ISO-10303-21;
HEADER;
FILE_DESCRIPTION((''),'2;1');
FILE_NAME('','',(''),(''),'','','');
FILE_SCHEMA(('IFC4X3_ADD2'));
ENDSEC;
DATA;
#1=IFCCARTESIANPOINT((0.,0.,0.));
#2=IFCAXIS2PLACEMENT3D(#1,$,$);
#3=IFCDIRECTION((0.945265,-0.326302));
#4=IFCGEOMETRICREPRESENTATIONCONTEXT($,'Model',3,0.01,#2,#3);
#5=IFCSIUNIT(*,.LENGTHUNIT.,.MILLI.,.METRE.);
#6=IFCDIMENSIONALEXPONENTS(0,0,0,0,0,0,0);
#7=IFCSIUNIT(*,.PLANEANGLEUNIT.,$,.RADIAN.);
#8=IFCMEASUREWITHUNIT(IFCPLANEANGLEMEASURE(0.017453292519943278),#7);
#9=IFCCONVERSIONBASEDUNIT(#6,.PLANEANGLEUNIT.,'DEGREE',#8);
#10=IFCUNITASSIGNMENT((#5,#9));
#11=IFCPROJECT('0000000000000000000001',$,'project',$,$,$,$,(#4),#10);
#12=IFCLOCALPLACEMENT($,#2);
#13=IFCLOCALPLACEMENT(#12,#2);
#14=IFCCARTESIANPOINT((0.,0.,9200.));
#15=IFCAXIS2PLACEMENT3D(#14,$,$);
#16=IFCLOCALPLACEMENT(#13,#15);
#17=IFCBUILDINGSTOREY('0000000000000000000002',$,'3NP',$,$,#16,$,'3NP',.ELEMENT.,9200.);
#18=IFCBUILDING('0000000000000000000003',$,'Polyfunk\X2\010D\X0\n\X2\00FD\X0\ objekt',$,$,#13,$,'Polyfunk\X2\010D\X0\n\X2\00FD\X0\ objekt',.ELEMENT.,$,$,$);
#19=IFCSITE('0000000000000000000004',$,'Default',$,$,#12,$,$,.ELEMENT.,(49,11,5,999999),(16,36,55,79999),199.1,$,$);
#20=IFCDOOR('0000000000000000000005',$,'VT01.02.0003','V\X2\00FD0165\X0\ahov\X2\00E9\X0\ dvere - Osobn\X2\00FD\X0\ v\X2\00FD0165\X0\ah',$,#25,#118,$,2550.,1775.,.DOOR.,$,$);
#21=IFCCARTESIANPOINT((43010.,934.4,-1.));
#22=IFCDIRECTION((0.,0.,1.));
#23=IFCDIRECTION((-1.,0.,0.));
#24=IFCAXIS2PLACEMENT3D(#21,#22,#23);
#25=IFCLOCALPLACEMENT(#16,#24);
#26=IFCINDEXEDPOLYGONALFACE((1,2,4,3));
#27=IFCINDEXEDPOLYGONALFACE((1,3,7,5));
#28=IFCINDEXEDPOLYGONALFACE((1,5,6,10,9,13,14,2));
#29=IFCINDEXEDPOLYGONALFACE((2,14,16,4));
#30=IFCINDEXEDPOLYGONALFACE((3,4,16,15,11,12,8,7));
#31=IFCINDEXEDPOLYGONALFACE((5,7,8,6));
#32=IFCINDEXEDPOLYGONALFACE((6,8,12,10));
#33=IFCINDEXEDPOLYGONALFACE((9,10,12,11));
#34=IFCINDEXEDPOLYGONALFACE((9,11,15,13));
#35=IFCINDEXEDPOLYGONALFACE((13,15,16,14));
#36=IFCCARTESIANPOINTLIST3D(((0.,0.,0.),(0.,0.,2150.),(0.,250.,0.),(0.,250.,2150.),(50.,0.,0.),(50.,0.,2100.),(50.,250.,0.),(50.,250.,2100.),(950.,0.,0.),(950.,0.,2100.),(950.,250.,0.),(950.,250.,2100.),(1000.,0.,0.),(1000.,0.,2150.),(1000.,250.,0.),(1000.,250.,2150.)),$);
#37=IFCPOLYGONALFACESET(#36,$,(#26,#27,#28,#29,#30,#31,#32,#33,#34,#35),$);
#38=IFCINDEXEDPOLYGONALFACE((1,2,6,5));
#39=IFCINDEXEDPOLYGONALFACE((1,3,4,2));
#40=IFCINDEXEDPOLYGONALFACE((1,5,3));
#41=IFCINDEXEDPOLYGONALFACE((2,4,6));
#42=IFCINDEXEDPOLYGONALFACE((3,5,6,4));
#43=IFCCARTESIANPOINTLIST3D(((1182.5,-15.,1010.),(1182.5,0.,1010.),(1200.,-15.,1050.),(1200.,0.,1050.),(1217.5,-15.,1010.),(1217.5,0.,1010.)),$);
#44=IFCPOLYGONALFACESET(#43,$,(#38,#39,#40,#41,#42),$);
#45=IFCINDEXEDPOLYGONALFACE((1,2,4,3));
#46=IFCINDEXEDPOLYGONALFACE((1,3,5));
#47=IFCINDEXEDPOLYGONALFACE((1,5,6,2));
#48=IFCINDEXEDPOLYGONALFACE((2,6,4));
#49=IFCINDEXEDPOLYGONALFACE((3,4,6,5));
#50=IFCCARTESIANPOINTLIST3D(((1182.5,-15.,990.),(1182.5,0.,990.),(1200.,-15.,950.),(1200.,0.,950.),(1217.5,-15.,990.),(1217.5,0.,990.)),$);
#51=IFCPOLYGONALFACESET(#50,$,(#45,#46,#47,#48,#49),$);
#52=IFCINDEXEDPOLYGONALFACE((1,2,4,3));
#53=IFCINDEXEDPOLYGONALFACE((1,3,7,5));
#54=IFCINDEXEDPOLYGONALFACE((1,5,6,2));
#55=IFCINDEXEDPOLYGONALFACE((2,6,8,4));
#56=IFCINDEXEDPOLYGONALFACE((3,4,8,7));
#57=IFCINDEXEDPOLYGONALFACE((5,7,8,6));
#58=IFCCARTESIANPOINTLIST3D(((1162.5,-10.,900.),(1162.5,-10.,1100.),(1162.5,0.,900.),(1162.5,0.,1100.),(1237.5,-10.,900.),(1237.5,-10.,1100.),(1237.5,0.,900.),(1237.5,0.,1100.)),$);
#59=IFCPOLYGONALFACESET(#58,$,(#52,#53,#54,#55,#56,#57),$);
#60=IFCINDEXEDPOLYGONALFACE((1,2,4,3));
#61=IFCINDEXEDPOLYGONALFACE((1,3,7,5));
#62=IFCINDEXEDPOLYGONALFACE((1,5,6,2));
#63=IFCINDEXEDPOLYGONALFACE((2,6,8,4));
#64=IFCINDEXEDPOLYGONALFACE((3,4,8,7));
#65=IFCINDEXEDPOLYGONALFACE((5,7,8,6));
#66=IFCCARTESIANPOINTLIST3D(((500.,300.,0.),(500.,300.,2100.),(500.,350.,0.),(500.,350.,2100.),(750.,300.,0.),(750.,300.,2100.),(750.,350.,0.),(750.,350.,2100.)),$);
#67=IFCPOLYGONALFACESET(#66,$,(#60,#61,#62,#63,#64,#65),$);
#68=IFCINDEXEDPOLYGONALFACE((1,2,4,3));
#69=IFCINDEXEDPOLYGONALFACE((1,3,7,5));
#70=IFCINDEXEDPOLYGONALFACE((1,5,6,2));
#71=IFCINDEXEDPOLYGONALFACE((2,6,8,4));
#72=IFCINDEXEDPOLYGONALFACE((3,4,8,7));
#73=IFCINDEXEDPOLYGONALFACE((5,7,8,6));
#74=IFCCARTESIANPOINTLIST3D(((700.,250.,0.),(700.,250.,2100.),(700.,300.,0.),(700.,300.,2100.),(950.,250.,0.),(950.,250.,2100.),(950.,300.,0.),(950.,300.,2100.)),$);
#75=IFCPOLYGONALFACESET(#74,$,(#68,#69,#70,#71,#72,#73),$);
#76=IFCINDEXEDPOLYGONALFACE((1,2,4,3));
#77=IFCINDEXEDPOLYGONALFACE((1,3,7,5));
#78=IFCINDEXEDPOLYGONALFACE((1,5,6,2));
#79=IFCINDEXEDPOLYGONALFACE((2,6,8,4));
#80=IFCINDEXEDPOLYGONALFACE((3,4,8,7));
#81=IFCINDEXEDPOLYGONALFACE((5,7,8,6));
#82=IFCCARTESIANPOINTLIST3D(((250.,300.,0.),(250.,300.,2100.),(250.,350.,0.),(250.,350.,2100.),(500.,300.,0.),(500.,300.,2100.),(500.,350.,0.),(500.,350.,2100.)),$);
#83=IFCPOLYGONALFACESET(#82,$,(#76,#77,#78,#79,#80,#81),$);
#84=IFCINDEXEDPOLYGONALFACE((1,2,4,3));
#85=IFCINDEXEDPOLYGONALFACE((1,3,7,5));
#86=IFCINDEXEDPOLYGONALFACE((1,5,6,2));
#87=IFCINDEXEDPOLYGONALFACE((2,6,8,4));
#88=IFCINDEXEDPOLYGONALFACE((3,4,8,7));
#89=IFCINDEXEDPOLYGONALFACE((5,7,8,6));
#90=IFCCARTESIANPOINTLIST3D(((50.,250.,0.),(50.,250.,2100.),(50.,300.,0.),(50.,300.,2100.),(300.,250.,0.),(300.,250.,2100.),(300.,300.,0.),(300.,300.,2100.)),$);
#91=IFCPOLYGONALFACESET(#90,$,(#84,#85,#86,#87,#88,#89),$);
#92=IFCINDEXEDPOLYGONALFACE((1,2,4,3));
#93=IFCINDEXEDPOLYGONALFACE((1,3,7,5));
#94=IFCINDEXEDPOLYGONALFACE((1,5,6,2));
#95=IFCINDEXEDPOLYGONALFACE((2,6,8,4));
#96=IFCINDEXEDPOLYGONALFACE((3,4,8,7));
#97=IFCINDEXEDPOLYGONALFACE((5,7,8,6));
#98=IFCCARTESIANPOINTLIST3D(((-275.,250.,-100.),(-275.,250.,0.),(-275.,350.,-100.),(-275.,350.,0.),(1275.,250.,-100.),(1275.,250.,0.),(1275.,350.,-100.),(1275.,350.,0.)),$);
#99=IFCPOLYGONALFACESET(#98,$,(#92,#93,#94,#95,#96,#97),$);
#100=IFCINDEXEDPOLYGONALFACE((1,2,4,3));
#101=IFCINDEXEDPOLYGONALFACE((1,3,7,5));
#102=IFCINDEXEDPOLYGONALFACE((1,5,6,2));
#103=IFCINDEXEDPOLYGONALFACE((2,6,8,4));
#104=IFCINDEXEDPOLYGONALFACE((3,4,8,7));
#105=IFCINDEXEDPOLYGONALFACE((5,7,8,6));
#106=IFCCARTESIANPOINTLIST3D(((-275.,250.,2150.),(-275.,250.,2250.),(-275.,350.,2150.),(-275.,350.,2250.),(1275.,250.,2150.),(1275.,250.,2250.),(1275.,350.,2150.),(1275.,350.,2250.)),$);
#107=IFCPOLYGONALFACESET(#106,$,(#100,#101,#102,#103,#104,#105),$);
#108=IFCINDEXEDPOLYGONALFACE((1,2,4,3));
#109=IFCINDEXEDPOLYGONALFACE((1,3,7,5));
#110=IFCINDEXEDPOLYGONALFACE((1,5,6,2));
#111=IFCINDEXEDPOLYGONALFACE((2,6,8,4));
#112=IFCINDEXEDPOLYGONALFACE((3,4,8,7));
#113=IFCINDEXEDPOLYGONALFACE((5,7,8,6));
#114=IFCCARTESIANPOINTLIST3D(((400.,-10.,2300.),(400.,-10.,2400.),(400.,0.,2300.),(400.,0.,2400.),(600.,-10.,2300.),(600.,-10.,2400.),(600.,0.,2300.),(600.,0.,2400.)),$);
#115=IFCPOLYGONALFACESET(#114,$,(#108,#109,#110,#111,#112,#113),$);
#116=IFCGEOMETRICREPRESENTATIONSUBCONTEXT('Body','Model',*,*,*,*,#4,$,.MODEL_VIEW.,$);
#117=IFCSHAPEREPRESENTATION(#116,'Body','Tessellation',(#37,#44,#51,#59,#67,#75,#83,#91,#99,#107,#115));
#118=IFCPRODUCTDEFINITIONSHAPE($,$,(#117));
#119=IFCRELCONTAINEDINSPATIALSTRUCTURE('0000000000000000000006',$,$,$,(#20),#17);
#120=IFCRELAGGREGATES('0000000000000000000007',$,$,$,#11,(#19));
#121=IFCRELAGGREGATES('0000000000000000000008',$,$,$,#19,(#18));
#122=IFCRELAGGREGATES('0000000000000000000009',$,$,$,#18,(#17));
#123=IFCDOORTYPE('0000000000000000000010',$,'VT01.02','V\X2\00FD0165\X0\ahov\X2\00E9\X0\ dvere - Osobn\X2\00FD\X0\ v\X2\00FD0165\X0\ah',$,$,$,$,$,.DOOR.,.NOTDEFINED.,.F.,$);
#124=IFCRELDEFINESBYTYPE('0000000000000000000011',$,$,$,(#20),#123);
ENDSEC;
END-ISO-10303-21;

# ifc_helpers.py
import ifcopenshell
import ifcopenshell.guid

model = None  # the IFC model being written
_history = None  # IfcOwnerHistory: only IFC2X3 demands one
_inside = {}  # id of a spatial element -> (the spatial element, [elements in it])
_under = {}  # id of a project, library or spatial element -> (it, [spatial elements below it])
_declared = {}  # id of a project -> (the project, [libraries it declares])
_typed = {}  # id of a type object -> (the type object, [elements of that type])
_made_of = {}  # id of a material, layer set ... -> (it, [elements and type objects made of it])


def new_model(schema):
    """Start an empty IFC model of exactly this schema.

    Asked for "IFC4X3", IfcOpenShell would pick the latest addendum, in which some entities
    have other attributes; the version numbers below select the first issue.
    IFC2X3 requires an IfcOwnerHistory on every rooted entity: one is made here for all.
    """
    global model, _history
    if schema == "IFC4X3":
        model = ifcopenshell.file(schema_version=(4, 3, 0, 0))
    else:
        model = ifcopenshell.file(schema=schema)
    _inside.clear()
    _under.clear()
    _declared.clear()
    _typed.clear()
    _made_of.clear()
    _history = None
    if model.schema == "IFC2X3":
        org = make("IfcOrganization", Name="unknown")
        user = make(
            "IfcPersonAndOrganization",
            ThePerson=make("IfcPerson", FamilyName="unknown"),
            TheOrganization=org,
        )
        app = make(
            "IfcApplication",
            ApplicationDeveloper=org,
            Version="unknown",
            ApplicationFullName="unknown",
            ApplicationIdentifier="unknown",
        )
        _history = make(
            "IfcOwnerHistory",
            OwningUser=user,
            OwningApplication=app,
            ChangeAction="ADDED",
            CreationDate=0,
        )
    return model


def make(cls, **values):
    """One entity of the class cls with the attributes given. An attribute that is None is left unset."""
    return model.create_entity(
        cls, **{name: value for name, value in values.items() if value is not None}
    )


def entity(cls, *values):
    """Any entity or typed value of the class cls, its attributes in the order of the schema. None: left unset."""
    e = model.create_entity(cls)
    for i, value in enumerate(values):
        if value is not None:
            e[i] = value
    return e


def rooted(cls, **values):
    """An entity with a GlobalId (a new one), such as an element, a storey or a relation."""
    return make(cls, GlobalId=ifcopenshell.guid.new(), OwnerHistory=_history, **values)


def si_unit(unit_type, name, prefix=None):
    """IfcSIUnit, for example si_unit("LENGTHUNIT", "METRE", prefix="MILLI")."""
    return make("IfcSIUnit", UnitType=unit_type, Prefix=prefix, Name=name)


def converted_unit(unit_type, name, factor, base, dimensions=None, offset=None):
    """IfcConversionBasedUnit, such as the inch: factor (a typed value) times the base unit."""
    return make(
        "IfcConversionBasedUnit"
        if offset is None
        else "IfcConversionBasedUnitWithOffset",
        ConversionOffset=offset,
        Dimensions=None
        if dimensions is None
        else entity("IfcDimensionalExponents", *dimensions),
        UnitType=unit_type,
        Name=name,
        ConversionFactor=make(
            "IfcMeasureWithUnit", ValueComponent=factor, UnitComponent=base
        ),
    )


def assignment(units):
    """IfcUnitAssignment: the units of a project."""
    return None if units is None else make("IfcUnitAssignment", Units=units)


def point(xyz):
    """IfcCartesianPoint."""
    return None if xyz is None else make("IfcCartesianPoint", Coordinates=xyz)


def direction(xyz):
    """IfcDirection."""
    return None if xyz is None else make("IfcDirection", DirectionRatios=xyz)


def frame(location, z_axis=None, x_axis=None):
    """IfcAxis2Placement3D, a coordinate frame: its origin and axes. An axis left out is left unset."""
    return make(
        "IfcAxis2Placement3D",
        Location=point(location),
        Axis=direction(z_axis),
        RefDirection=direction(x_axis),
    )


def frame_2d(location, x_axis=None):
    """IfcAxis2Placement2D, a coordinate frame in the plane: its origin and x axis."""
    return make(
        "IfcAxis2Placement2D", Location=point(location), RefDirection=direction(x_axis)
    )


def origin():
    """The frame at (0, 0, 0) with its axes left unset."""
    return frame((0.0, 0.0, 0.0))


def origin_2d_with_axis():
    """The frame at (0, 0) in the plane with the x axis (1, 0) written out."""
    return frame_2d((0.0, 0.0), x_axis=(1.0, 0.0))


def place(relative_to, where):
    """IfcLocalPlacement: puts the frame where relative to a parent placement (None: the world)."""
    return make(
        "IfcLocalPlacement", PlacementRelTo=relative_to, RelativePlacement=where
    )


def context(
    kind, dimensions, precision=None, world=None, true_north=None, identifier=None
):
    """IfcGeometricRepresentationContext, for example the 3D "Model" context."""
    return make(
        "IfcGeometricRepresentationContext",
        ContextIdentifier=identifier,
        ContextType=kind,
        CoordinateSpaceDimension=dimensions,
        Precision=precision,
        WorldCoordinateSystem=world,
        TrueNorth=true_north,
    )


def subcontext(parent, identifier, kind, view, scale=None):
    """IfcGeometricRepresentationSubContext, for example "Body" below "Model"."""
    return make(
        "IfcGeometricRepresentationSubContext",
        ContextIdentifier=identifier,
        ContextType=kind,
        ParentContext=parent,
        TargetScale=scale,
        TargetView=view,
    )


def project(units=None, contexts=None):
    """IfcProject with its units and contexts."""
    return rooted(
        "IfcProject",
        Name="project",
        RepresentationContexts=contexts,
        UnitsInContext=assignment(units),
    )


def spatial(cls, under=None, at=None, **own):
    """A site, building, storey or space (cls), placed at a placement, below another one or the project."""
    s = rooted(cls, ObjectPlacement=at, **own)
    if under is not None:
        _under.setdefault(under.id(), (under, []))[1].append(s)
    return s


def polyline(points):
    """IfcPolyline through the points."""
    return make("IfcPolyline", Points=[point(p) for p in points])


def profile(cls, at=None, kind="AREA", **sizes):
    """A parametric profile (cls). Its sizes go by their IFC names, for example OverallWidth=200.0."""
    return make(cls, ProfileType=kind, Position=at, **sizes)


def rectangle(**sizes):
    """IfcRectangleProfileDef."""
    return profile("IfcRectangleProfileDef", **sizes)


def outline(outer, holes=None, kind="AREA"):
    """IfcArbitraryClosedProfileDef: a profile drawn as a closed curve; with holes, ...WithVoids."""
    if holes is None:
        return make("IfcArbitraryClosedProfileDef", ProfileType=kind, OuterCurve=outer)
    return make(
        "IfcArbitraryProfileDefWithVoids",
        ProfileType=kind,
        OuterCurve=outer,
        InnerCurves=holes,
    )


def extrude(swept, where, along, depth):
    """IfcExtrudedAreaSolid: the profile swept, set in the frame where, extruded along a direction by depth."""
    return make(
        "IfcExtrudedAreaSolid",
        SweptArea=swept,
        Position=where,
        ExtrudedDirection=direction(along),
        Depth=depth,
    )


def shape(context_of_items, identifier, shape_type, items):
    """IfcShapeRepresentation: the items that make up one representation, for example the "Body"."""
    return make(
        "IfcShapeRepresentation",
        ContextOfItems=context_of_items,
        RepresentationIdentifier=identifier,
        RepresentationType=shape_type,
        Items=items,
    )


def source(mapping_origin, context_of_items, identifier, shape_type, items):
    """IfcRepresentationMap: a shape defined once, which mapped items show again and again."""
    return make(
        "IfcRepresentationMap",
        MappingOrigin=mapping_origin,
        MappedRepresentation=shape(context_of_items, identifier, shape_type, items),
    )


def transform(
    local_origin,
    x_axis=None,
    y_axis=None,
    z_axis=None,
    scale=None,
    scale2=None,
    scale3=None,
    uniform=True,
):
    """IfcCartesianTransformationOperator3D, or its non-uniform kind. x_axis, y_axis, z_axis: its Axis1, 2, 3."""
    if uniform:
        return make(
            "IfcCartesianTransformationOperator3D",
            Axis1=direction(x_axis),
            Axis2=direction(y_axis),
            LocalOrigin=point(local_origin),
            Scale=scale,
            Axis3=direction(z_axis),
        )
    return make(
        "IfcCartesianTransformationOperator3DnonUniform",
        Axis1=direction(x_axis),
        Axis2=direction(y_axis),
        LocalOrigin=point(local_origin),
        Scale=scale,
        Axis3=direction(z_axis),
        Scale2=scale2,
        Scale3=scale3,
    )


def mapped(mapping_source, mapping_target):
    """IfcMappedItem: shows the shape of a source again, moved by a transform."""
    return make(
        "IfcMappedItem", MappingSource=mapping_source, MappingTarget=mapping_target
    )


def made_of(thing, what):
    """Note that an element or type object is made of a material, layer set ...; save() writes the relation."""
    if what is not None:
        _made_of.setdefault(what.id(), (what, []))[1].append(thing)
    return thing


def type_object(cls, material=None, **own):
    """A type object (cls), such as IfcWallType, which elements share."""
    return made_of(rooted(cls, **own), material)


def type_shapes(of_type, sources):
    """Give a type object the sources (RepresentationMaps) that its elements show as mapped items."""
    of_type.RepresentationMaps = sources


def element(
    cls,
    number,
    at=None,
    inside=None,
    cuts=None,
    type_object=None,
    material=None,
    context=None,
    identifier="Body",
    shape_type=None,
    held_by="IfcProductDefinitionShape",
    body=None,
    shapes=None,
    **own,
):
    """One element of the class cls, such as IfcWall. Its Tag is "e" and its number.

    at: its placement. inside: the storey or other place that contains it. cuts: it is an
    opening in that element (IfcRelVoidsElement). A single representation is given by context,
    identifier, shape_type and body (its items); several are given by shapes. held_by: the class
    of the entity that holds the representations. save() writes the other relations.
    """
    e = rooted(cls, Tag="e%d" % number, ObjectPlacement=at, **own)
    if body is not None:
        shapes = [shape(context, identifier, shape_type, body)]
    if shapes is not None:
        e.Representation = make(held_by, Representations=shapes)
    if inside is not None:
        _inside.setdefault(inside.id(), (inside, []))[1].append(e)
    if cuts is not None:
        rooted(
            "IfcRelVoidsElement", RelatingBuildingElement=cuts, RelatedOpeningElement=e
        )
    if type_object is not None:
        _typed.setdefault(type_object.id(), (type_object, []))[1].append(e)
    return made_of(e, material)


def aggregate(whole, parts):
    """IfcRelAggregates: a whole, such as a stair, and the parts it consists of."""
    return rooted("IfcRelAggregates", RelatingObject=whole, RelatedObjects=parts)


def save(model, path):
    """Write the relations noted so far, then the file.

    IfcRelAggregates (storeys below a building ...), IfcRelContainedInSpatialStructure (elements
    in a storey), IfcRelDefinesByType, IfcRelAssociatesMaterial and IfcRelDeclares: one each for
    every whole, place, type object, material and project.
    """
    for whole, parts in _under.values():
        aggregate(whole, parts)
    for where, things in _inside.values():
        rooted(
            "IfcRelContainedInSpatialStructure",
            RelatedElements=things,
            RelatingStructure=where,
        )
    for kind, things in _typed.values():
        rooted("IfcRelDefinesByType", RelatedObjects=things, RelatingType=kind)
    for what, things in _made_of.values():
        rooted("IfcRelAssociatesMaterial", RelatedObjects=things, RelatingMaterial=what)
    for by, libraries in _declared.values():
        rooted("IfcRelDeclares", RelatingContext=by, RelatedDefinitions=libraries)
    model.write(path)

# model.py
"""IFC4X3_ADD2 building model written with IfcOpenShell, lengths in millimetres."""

from ifc_helpers import new_model, entity, si_unit, converted_unit, direction, frame, frame_2d, origin, origin_2d_with_axis, place, context, subcontext, project, spatial, polyline, rectangle, outline, extrude, source, transform, mapped, type_object, type_shapes, element, save


model = new_model("IFC4X3_ADD2")

# Units and contexts
model_context = context("Model", 3, precision=0.01, world=origin(), true_north=direction((0.945265, -0.326302)))
body_context = subcontext(model_context, "Body", "Model", "MODEL_VIEW")
ifc_project = project(units=[si_unit("LENGTHUNIT", "METRE", prefix="MILLI"), converted_unit("PLANEANGLEUNIT", "DEGREE", entity("IfcPlaneAngleMeasure", 0.017453292519943278), si_unit("PLANEANGLEUNIT", "RADIAN"), dimensions=[0, 0, 0, 0, 0, 0, 0])], contexts=[model_context])

# Site, building, storey
site_placement = place(None, origin())
site = spatial("IfcSite", under=ifc_project, at=site_placement, Name="Default", CompositionType="ELEMENT", RefLatitude=(49, 11, 5, 999999), RefLongitude=(16, 36, 55, 79999), RefElevation=199.1)
building_placement = place(site_placement, origin())
building = spatial("IfcBuilding", under=site, at=building_placement, Name="Polyfunkčný objekt", LongName="Polyfunkčný objekt", CompositionType="ELEMENT")
storey_placement = place(building_placement, frame((0.0, 0.0, 9200.0)))
storey = spatial("IfcBuildingStorey", under=building, at=storey_placement, Name="3NP", LongName="3NP", CompositionType="ELEMENT", Elevation=9200.0)

# Door
door_type = type_object("IfcDoorType", Name="VT01.02", Description="Výťahové dvere - Osobný výťah", OperationType="NOTDEFINED", ParameterTakesPrecedence=False, PredefinedType="DOOR")
shared_shape_1 = source(origin(), body_context, "Body", "SweptSolid", [
    extrude(outline(polyline([(-1087.5, -500.0), (1062.5, -500.0), (1062.5, -450.0), (-1037.5, -450.0), (-1037.5, 450.0), (1062.5, 450.0), (1062.5, 500.0), (-1087.5, 500.0), (-1087.5, -500.0)])), frame((500.0, 0.0, 1062.5), z_axis=(0.0, 1.0, 0.0), x_axis=(0.0, 0.0, -1.0)), (0.0, 0.0, 1.0), 250.0),
    extrude(outline(polyline([(-24.4, -10.7), (19.2, -10.7), (5.2, 21.4), (-24.4, -10.7)])), frame((1200.0, -15.0, 1023.3), z_axis=(0.0, 1.0, 0.0), x_axis=(0.400819, 0.0, -0.916157)), (0.0, 0.0, 1.0), 15.0),
    extrude(outline(polyline([(-24.4, -10.7), (19.2, -10.7), (5.2, 21.4), (-24.4, -10.7)])), frame((1200.0, -15.0, 976.7), z_axis=(0.0, 1.0, 0.0), x_axis=(-0.400819, 0.0, 0.916157)), (0.0, 0.0, 1.0), 15.0),
    extrude(rectangle(XDim=10.0, YDim=75.0, at=frame_2d((0.0, 0.0), x_axis=(1.0, 0.0))), frame((1200.0, -5.0, 900.0), z_axis=(0.0, 0.0, 1.0), x_axis=(0.0, 1.0, 0.0)), (0.0, 0.0, 1.0), 200.0),
    extrude(rectangle(XDim=50.0, YDim=250.0, at=origin_2d_with_axis()), frame((625.0, 325.0, 0.0), z_axis=(0.0, 0.0, 1.0), x_axis=(0.0, -1.0, 0.0)), (0.0, 0.0, 1.0), 2100.0),
    extrude(rectangle(XDim=50.0, YDim=250.0, at=frame_2d((0.0, 0.0), x_axis=(1.0, 0.0))), frame((825.0, 275.0, 0.0), z_axis=(0.0, 0.0, 1.0), x_axis=(0.0, -1.0, 0.0)), (0.0, 0.0, 1.0), 2100.0),
    extrude(rectangle(XDim=250.0, YDim=50.0, at=frame_2d((0.0, 0.0), x_axis=(1.0, 0.0))), frame((375.0, 325.0, 0.0), z_axis=(0.0, 0.0, 1.0), x_axis=(-1.0, 0.0, 0.0)), (0.0, 0.0, 1.0), 2100.0),
    extrude(rectangle(XDim=250.0, YDim=50.0, at=frame_2d((0.0, 0.0), x_axis=(1.0, 0.0))), frame((175.0, 275.0, 0.0), z_axis=(0.0, 0.0, 1.0), x_axis=(-1.0, 0.0, 0.0)), (0.0, 0.0, 1.0), 2100.0),
    extrude(rectangle(XDim=1550.0, YDim=100.0, at=frame_2d((0.0, 0.0), x_axis=(1.0, 0.0))), frame((500.0, 300.0, -100.0), z_axis=(0.0, 0.0, 1.0), x_axis=(-1.0, 0.0, 0.0)), (0.0, 0.0, 1.0), 100.0),
    extrude(rectangle(XDim=1550.0, YDim=100.0, at=frame_2d((0.0, 0.0), x_axis=(1.0, 0.0))), frame((500.0, 300.0, 2150.0), z_axis=(0.0, 0.0, 1.0), x_axis=(-1.0, 0.0, 0.0)), (0.0, 0.0, 1.0), 100.0),
    extrude(rectangle(XDim=10.0, YDim=200.0, at=frame_2d((0.0, 0.0), x_axis=(1.0, 0.0))), frame((500.0, -5.0, 2300.0), z_axis=(0.0, 0.0, 1.0), x_axis=(0.0, 1.0, 0.0)), (0.0, 0.0, 1.0), 100.0),
])
type_shapes(door_type, [shared_shape_1])
door_placement = place(storey_placement, frame((43010.0, 934.4, -1.0), z_axis=(0.0, 0.0, 1.0), x_axis=(-1.0, 0.0, 0.0)))
element("IfcDoor", 1, at=door_placement, inside=storey, type_object=door_type, Name="VT01.02.0003", Description="Výťahové dvere - Osobný výťah", OverallHeight=2550.0, OverallWidth=1775.0, PredefinedType="DOOR", context=body_context, shape_type="MappedRepresentation", body=[
    mapped(shared_shape_1, transform((0.0, 0.0, 0.0), scale=1.0)),
])

save(model, "model.ifc")
